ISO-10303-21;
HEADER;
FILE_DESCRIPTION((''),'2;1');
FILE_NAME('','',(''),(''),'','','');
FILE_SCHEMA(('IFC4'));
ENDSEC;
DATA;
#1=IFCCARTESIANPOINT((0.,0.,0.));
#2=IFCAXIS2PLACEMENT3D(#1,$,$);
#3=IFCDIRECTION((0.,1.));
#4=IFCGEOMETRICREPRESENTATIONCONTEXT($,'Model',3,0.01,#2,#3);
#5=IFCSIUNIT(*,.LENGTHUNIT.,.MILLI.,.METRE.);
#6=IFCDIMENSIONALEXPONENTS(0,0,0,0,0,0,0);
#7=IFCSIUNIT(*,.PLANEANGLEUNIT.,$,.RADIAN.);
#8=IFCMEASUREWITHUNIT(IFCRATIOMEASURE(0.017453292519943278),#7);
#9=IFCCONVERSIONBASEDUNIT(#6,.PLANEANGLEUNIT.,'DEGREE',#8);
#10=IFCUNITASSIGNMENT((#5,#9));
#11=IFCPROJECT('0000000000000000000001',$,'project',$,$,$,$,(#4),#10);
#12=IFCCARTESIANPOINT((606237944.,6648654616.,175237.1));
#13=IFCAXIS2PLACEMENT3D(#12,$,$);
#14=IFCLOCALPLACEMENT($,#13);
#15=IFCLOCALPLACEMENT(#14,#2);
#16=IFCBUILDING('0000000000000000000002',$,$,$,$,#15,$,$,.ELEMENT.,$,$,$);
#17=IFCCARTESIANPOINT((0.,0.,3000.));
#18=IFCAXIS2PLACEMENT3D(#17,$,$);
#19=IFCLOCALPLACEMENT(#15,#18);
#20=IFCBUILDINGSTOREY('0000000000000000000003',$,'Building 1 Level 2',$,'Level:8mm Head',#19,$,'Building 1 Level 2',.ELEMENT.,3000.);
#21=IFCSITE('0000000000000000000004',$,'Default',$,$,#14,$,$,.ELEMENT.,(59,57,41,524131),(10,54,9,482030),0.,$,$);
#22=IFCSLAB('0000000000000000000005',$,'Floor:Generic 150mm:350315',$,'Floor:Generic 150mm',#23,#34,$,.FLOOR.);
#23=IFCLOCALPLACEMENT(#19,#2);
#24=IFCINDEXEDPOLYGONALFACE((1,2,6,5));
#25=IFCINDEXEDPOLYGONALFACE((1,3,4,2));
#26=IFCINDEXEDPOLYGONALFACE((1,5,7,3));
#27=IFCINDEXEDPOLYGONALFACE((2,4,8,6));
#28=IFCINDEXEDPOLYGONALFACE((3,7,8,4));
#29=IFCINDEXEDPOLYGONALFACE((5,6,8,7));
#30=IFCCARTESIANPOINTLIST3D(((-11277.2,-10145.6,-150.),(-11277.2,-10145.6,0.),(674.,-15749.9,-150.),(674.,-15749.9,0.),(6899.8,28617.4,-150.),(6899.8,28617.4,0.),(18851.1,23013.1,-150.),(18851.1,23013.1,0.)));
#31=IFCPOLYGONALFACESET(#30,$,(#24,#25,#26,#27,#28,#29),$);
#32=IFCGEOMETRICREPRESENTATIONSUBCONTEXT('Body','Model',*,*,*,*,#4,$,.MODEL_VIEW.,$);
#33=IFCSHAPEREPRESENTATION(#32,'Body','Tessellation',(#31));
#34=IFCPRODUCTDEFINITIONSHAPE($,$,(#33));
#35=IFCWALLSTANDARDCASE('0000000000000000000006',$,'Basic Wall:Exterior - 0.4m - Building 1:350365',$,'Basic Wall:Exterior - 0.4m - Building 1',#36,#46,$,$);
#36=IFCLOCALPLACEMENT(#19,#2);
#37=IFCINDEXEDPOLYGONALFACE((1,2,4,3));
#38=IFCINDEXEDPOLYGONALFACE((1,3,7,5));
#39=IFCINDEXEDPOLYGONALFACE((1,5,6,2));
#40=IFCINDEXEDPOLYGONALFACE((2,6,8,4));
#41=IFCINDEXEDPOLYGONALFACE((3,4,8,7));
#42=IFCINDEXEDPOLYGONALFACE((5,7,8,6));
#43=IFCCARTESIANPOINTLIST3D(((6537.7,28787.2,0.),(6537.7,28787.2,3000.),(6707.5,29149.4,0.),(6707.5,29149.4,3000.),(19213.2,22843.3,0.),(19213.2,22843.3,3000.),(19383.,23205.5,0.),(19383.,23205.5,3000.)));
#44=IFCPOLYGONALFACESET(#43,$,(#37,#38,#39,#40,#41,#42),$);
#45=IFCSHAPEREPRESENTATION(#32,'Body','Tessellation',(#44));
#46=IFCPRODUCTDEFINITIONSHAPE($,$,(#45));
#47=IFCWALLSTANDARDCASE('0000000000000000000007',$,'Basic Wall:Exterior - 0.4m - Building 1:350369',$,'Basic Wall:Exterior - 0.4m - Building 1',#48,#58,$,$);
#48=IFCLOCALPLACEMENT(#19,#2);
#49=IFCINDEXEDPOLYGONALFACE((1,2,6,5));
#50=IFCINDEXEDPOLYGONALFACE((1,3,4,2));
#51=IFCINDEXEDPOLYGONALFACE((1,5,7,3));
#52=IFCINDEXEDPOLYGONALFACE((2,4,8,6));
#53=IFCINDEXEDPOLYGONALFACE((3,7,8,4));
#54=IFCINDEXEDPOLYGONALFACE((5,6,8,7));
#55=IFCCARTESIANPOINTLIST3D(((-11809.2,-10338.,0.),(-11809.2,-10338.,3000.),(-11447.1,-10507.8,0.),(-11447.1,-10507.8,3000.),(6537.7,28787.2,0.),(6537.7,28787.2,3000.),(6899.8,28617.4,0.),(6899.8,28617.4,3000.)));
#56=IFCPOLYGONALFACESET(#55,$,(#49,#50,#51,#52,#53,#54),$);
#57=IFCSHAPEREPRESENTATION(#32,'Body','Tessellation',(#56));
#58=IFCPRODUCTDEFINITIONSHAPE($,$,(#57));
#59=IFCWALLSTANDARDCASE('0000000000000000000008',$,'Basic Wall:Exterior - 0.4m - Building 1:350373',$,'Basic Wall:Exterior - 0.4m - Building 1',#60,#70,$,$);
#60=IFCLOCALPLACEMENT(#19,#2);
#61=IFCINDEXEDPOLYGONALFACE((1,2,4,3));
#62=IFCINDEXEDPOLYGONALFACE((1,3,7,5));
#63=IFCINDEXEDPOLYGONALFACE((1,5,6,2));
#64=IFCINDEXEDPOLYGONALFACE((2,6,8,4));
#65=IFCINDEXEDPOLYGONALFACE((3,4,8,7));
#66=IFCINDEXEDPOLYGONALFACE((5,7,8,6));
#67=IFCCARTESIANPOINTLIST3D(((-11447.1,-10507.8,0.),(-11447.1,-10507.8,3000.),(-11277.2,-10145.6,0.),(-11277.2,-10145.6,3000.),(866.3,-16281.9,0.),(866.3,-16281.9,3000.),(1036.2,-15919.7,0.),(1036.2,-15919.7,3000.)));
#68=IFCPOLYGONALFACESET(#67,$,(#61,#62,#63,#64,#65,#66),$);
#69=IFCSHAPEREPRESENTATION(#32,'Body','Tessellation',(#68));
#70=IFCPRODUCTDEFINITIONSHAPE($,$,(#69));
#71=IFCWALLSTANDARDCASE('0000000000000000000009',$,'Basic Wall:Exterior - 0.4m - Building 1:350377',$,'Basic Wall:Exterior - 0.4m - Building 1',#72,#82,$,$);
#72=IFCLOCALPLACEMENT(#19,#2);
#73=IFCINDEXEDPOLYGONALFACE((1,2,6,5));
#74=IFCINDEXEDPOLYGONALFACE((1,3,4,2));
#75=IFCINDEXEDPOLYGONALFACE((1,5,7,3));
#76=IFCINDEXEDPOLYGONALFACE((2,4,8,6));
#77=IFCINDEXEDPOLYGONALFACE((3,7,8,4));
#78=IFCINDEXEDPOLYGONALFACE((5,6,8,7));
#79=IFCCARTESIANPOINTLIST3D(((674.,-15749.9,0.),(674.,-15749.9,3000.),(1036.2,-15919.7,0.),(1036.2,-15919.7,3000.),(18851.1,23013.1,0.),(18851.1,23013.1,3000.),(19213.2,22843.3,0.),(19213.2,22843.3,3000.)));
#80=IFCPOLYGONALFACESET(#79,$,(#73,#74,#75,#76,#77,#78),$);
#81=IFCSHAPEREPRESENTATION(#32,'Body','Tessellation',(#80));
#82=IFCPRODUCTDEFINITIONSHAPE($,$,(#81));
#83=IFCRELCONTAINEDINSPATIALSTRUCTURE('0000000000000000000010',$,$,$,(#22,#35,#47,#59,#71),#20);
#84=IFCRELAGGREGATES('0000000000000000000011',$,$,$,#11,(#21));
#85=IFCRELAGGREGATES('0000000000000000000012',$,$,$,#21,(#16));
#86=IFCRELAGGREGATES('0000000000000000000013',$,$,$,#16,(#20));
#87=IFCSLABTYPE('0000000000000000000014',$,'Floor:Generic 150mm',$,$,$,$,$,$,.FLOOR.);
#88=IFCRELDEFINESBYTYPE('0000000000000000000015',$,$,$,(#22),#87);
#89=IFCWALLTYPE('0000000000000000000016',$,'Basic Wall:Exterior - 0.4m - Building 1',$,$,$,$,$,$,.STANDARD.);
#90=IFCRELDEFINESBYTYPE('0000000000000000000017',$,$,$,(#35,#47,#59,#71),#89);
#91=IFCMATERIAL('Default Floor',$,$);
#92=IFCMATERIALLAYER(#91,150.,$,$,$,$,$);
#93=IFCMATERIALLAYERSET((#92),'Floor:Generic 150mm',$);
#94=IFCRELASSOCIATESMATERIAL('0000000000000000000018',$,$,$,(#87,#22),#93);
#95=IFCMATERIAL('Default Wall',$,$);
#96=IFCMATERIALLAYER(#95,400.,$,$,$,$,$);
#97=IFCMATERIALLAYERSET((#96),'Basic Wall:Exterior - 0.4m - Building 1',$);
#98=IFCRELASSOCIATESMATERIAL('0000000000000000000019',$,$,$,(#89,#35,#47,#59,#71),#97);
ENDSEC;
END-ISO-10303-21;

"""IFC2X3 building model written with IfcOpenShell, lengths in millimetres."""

from ifc_helpers import new_model, entity, si_unit, converted_unit, direction, frame, frame_2d, origin, place, context, subcontext, project, spatial, rectangle, extrude, material, layer, layer_set, layer_usage, type_object, element, save


model = new_model("IFC2X3")

# Units and contexts
model_context = context("Model", 3, precision=0.01, world=origin(), true_north=direction((0.0, 1.0)))
body_context = subcontext(model_context, "Body", "Model", "MODEL_VIEW")
ifc_project = project(units=[si_unit("LENGTHUNIT", "METRE", prefix="MILLI"), converted_unit("PLANEANGLEUNIT", "DEGREE", entity("IfcRatioMeasure", 0.017453292519943278), si_unit("PLANEANGLEUNIT", "RADIAN"), dimensions=[0, 0, 0, 0, 0, 0, 0])], contexts=[model_context])

# Site, building, storey
site_placement = place(None, frame((606237944.0, 6648654616.0, 175237.1)))
site = spatial("IfcSite", under=ifc_project, at=site_placement, Name="Default", CompositionType="ELEMENT", RefLatitude=(59, 57, 41, 524131), RefLongitude=(10, 54, 9, 482030), RefElevation=0.0)
building_placement = place(site_placement, origin())
building = spatial("IfcBuilding", under=site, at=building_placement, CompositionType="ELEMENT")
storey_placement = place(building_placement, frame((0.0, 0.0, 3000.0)))
storey = spatial("IfcBuildingStorey", under=building, at=storey_placement, Name="Building 1 Level 2", ObjectType="Level:8mm Head", LongName="Building 1 Level 2", CompositionType="ELEMENT", Elevation=3000.0)

# Slab
ifc_material_1 = material(Name="Default Floor")
ifc_layer_1 = layer(ifc_material_1, 150.0)
ifc_layer_set_1 = layer_set([ifc_layer_1], Name="Floor:Generic 150mm")
ifc_layer_usage_1 = layer_usage(ifc_layer_set_1, "AXIS3", "POSITIVE", 0.0)
slab_type = type_object("IfcSlabType", Name="Floor:Generic 150mm", PredefinedType="FLOOR", material=ifc_layer_set_1)
slab_placement = place(storey_placement, origin())
element("IfcSlab", 1, at=slab_placement, inside=storey, type_object=slab_type, material=ifc_layer_usage_1, Name="Floor:Generic 150mm:350315", ObjectType="Floor:Generic 150mm", PredefinedType="FLOOR", context=body_context, shape_type="SweptSolid", body=[
    extrude(rectangle(XDim=13200.0, YDim=42813.3, at=frame_2d((0.0, 0.0), x_axis=(1.0, 0.0))), frame((3786.9, 6433.8, 0.0), z_axis=(0.0, 0.0, -1.0), x_axis=(0.905397, -0.424566, 0.0)), (0.0, 0.0, 1.0), 150.0),
])

# Walls
ifc_material_2 = material(Name="Default Wall")
ifc_layer_2 = layer(ifc_material_2, 400.0)
ifc_layer_set_2 = layer_set([ifc_layer_2], Name="Basic Wall:Exterior - 0.4m - Building 1")
ifc_layer_usage_2 = layer_usage(ifc_layer_set_2, "AXIS2", "POSITIVE", -200.0)
wall_type = type_object("IfcWallType", Name="Basic Wall:Exterior - 0.4m - Building 1", PredefinedType="STANDARD", material=ifc_layer_set_2)
wall_1_placement = place(storey_placement, frame((19298.1, 23024.4, 0.0), z_axis=(0.0, 0.0, 1.0), x_axis=(-0.905397, 0.424566, 0.0)))
element("IfcWallStandardCase", 2, at=wall_1_placement, inside=storey, type_object=wall_type, material=ifc_layer_usage_2, Name="Basic Wall:Exterior - 0.4m - Building 1:350365", ObjectType="Basic Wall:Exterior - 0.4m - Building 1", context=body_context, shape_type="SweptSolid", body=[
    extrude(rectangle(XDim=14000.0, YDim=400.0, at=frame_2d((7000.0, 0.0), x_axis=(-1.0, 0.0))), origin(), (0.0, 0.0, 1.0), 3000.0),
])
wall_2_placement = place(storey_placement, frame((6718.7, 28702.3, 0.0), z_axis=(0.0, 0.0, 1.0), x_axis=(-0.424566, -0.905397, 0.0)))
element("IfcWallStandardCase", 3, at=wall_2_placement, inside=storey, type_object=wall_type, material=ifc_layer_usage_2, Name="Basic Wall:Exterior - 0.4m - Building 1:350369", ObjectType="Basic Wall:Exterior - 0.4m - Building 1", context=body_context, shape_type="SweptSolid", body=[
    extrude(rectangle(XDim=43213.3, YDim=400.0, at=frame_2d((21606.7, 0.0), x_axis=(-1.0, 0.0))), origin(), (0.0, 0.0, 1.0), 3000.0),
])
wall_3_placement = place(storey_placement, frame((-11362.2, -10326.7, 0.0), z_axis=(0.0, 0.0, 1.0), x_axis=(0.905397, -0.424566, 0.0)))
element("IfcWallStandardCase", 4, at=wall_3_placement, inside=storey, type_object=wall_type, material=ifc_layer_usage_2, Name="Basic Wall:Exterior - 0.4m - Building 1:350373", ObjectType="Basic Wall:Exterior - 0.4m - Building 1", context=body_context, shape_type="SweptSolid", body=[
    extrude(rectangle(XDim=13600.0, YDim=400.0, at=frame_2d((6800.0, 0.0), x_axis=(-1.0, 0.0))), origin(), (0.0, 0.0, 1.0), 3000.0),
])
wall_4_placement = place(storey_placement, frame((855.1, -15834.8, 0.0), z_axis=(0.0, 0.0, 1.0), x_axis=(0.424566, 0.905397, 0.0)))
element("IfcWallStandardCase", 5, at=wall_4_placement, inside=storey, type_object=wall_type, material=ifc_layer_usage_2, Name="Basic Wall:Exterior - 0.4m - Building 1:350377", ObjectType="Basic Wall:Exterior - 0.4m - Building 1", context=body_context, shape_type="SweptSolid", body=[
    extrude(rectangle(XDim=42813.3, YDim=400.0, at=frame_2d((21406.7, 0.0), x_axis=(-1.0, 0.0))), origin(), (0.0, 0.0, 1.0), 3000.0),
])

save(model, "model.ifc")
